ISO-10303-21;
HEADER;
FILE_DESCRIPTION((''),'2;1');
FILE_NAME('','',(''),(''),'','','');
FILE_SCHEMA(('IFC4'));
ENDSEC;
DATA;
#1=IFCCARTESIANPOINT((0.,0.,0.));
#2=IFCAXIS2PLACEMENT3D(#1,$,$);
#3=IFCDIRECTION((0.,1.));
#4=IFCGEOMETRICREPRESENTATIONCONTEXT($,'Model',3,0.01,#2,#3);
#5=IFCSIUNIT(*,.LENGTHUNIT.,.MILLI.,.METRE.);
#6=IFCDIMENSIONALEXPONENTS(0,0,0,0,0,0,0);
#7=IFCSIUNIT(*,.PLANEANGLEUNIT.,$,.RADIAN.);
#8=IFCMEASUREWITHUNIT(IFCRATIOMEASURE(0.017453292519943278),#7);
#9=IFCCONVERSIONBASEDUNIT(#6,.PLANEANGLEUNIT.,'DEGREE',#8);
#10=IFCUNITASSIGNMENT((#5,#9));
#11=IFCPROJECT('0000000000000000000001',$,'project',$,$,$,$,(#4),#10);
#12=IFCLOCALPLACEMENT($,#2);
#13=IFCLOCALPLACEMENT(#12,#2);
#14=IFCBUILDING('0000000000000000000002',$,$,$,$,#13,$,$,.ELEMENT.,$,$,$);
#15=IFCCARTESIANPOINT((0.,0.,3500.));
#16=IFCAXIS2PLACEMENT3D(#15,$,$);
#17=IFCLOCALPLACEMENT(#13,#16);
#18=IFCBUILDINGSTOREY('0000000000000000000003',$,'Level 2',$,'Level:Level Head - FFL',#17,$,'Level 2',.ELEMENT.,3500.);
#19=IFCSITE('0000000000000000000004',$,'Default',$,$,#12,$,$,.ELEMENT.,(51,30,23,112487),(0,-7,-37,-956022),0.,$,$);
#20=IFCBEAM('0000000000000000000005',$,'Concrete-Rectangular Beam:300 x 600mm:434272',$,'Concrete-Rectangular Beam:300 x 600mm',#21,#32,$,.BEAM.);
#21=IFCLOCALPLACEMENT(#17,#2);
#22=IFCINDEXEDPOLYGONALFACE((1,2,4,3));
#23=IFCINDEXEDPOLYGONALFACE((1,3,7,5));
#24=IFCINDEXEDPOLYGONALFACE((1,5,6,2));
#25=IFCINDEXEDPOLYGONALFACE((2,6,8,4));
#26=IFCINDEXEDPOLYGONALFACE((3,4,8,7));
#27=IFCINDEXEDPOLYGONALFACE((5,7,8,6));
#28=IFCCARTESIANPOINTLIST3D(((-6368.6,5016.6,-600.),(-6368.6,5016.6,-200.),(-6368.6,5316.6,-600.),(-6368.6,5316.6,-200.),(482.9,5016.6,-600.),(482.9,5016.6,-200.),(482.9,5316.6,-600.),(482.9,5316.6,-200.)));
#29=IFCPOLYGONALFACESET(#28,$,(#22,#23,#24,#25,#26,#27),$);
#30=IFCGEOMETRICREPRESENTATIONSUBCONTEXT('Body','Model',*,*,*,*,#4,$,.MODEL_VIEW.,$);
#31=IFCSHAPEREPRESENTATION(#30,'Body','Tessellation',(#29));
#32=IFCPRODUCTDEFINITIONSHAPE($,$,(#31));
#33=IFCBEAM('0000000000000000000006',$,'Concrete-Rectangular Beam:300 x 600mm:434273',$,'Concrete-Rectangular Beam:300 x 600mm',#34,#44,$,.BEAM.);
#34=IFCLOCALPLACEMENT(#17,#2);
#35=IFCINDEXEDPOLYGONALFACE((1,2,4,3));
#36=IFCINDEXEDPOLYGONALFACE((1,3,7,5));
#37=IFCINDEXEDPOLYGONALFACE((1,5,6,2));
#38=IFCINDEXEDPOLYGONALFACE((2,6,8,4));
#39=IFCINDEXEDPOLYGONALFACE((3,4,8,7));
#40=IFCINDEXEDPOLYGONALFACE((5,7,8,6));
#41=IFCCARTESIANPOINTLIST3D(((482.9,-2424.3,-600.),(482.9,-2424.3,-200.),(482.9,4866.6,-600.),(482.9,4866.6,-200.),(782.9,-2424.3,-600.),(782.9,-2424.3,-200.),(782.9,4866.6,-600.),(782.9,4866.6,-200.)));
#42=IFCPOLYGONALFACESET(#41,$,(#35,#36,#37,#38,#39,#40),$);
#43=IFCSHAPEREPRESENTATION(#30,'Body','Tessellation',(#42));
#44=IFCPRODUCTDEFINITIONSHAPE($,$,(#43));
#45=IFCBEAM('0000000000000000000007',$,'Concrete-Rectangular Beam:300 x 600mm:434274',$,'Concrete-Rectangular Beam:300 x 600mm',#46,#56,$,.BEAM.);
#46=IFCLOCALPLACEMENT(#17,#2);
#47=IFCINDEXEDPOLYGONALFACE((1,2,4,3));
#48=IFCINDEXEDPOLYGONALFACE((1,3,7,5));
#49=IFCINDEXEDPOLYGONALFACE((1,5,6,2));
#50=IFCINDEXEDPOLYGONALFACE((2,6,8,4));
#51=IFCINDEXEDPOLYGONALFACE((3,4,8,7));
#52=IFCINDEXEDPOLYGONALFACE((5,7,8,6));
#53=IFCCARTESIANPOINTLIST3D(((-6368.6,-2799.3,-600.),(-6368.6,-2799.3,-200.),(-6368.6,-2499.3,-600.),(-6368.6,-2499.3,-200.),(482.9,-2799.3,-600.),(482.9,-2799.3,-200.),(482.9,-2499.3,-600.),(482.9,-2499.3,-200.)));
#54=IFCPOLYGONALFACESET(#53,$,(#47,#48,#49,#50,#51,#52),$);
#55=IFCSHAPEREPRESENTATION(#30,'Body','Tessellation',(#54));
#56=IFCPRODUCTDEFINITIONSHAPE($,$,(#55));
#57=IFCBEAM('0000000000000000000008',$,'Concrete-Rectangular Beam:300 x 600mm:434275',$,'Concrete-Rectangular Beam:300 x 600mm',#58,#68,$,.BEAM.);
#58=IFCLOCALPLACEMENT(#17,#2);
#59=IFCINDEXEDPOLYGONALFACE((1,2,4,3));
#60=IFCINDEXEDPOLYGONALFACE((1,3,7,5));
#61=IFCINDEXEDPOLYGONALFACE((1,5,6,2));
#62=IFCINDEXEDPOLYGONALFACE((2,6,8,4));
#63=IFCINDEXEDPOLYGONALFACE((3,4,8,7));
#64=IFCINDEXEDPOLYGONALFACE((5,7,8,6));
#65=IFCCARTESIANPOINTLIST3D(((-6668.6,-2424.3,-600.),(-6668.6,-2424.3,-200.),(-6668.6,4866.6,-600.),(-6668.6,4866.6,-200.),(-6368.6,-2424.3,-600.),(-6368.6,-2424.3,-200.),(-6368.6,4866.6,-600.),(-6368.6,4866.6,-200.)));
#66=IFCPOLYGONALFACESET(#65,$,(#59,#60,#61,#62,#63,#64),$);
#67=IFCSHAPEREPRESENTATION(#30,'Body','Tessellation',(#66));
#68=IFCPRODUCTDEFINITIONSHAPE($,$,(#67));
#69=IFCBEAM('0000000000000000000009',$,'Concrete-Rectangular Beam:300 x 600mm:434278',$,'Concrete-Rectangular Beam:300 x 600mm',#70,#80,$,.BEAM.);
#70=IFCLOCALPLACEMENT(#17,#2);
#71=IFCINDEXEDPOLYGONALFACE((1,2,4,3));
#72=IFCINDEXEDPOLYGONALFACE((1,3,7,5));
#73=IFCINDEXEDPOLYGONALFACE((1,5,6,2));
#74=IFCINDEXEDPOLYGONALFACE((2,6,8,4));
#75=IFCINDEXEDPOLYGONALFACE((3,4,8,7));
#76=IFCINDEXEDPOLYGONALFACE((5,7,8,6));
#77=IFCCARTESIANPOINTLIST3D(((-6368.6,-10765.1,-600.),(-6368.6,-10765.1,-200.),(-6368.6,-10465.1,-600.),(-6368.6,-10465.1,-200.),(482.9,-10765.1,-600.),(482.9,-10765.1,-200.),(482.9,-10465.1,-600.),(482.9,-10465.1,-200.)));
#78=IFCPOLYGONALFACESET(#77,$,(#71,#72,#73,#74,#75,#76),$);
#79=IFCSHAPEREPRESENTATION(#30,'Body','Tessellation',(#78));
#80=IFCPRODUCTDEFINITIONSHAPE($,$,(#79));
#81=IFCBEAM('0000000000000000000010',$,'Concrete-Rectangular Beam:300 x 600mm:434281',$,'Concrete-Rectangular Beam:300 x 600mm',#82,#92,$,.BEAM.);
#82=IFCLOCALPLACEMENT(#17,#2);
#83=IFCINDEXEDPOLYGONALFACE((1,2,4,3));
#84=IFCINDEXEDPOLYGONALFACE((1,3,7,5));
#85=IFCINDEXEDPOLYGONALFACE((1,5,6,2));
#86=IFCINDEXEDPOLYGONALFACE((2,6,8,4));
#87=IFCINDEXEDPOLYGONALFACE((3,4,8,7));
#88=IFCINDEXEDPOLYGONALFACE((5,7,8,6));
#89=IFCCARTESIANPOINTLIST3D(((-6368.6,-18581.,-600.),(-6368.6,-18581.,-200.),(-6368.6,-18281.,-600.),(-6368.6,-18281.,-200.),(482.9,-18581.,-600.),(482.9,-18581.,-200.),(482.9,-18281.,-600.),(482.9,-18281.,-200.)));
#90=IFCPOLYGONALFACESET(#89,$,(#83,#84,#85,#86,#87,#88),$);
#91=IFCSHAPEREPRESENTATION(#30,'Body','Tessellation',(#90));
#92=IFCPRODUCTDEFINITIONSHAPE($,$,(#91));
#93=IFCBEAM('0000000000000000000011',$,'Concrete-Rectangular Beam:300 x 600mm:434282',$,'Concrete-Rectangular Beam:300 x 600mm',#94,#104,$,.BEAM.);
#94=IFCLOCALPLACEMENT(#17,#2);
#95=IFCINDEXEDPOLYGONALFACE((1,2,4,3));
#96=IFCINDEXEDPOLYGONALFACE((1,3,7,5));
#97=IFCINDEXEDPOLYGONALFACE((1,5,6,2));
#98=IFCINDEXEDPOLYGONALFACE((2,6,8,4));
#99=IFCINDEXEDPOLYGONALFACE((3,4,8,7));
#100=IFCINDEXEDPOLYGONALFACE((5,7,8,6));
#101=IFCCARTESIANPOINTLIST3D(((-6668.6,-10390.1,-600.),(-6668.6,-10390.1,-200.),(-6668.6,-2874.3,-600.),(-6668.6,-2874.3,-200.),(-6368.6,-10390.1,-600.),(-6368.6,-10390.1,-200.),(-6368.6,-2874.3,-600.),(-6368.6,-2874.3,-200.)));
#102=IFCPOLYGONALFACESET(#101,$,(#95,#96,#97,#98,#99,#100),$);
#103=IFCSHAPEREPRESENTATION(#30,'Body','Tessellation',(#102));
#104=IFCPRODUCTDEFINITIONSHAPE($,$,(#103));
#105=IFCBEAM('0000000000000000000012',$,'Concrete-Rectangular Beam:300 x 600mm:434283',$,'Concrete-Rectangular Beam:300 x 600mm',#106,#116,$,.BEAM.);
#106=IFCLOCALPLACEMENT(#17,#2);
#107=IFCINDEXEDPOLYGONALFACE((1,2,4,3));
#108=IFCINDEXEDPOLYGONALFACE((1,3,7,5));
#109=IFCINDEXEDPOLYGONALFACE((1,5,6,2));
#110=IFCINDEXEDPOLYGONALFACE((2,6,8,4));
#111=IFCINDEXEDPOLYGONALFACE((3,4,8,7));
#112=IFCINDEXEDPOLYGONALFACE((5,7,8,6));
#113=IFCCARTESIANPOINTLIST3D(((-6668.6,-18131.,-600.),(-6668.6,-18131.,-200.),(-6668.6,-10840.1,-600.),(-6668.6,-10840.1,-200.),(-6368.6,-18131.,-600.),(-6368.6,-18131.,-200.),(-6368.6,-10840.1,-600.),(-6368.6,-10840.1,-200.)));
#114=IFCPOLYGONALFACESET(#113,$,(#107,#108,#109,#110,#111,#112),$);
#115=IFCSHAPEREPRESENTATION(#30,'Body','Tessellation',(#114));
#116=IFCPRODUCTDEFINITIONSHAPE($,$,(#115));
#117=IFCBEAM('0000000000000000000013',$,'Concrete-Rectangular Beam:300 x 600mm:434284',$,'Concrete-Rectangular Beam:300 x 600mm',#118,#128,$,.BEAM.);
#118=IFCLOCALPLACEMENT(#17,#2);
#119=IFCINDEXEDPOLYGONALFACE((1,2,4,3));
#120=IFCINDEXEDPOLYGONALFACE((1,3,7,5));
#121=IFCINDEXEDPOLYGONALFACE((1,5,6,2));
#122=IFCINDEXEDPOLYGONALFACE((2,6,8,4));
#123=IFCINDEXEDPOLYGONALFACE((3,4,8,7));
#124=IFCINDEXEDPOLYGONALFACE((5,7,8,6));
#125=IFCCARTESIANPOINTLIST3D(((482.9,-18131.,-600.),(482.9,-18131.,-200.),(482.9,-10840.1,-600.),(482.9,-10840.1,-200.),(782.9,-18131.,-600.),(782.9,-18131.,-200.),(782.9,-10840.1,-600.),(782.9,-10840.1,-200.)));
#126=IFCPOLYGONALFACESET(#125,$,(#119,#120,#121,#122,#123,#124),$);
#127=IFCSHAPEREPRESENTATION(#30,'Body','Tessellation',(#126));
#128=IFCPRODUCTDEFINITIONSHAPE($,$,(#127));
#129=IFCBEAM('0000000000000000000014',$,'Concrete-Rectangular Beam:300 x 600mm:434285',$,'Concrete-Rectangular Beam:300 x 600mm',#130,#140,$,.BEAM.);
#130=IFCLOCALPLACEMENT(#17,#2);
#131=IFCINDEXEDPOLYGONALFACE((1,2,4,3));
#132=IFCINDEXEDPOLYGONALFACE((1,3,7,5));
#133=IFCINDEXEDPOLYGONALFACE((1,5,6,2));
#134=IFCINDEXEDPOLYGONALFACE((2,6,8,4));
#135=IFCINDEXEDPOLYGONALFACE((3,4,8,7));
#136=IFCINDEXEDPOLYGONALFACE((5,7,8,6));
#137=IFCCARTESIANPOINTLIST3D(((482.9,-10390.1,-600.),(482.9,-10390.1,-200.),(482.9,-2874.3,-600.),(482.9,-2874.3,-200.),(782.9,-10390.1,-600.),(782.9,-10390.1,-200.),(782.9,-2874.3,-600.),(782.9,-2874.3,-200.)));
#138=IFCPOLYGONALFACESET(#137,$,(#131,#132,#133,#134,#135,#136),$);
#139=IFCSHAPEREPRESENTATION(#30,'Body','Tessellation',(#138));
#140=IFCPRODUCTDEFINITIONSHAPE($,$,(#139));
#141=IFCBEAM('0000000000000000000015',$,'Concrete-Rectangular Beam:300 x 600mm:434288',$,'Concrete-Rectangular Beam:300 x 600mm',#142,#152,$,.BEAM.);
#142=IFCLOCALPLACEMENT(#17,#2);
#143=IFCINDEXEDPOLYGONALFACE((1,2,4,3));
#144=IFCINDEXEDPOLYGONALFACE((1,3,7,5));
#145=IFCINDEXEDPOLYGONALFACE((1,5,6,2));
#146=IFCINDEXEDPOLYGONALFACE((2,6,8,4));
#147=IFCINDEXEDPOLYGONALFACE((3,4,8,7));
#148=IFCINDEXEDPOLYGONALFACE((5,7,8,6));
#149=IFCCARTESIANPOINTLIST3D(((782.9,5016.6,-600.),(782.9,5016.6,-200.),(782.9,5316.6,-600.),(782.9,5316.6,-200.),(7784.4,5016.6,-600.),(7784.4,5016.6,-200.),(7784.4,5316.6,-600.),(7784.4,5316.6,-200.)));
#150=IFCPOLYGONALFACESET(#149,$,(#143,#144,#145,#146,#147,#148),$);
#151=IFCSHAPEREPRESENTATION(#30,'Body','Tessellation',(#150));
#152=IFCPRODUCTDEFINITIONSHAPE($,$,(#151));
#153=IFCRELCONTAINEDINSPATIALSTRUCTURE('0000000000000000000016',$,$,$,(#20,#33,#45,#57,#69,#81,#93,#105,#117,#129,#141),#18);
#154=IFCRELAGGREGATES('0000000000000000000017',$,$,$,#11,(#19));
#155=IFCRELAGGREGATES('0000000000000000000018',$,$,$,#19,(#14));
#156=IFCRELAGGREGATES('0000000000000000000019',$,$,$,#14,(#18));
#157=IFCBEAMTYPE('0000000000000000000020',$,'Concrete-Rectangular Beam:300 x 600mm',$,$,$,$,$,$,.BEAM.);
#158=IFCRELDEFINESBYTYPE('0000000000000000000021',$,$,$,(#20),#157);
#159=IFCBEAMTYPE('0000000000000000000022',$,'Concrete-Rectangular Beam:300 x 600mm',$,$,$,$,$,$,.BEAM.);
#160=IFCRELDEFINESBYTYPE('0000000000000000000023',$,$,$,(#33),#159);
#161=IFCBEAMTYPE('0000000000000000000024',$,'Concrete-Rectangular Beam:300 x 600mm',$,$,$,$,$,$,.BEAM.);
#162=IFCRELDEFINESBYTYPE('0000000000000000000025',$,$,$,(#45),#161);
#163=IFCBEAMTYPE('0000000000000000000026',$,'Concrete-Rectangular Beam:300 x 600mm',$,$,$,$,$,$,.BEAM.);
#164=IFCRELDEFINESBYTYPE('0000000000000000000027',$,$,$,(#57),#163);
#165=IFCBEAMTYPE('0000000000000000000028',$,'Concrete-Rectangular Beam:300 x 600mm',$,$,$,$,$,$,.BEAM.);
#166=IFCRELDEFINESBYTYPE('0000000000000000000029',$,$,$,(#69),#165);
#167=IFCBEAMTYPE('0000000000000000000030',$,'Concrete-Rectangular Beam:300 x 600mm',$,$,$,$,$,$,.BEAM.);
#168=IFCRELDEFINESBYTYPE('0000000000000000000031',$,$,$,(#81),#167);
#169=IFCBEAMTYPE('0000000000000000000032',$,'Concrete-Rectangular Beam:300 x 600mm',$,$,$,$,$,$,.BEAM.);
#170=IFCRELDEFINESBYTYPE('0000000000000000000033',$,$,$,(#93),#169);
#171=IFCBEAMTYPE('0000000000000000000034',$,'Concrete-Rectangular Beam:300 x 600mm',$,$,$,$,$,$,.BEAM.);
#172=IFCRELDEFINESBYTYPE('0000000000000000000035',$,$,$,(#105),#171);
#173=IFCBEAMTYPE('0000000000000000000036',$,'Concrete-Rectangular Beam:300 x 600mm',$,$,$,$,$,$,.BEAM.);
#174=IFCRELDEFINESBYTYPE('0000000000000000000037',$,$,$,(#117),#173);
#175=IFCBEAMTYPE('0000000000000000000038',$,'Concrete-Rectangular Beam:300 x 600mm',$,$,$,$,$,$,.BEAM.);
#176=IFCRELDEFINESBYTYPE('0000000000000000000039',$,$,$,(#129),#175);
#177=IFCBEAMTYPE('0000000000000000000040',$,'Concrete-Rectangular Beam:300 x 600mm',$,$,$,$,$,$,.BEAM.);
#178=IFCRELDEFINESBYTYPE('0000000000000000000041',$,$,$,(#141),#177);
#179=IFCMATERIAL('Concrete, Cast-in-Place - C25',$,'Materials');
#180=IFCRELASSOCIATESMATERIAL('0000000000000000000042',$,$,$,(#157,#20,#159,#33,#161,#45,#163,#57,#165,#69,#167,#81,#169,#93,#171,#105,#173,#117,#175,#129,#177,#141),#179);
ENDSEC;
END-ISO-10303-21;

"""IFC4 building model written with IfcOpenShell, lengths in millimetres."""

from ifc_helpers import new_model, entity, si_unit, converted_unit, direction, frame, origin, place, context, subcontext, project, spatial, indexed_curve, outline, extrude, source, transform, mapped, material, type_object, type_shapes, element, save


model = new_model("IFC4")

# Units and contexts
model_context = context("Model", 3, precision=0.01, world=origin(), true_north=direction((0.0, 1.0)))
body_context = subcontext(model_context, "Body", "Model", "MODEL_VIEW")
ifc_project = project(units=[si_unit("LENGTHUNIT", "METRE", prefix="MILLI"), converted_unit("PLANEANGLEUNIT", "DEGREE", entity("IfcRatioMeasure", 0.017453292519943278), si_unit("PLANEANGLEUNIT", "RADIAN"), dimensions=[0, 0, 0, 0, 0, 0, 0])], contexts=[model_context])

# Site, building, storey
site_placement = place(None, origin())
site = spatial("IfcSite", under=ifc_project, at=site_placement, Name="Default", CompositionType="ELEMENT", RefLatitude=(51, 30, 23, 112487), RefLongitude=(0, -7, -37, -956022), RefElevation=0.0)
building_placement = place(site_placement, origin())
building = spatial("IfcBuilding", under=site, at=building_placement, CompositionType="ELEMENT")
storey_placement = place(building_placement, frame((0.0, 0.0, 3500.0)))
storey = spatial("IfcBuildingStorey", under=building, at=storey_placement, Name="Level 2", ObjectType="Level:Level Head - FFL", LongName="Level 2", CompositionType="ELEMENT", Elevation=3500.0)

# Beams
ifc_material = material(Name="Concrete, Cast-in-Place - C25", Category="Materials")
beam_type_1 = type_object("IfcBeamType", Name="Concrete-Rectangular Beam:300 x 600mm", PredefinedType="BEAM", material=ifc_material)
shared_shape_1 = source(origin(), body_context, "Body", "SweptSolid", [
    extrude(outline(indexed_curve([(-200.0, -150.0), (200.0, -150.0), (200.0, 150.0), (-200.0, 150.0), (-200.0, -150.0)], self_intersect=False)), frame((-6368.6, 5166.6, 3100.0), z_axis=(1.0, 0.0, 0.0), x_axis=(0.0, 0.0, -1.0)), (0.0, 0.0, 1.0), 6851.5),
])
type_shapes(beam_type_1, [shared_shape_1])
beam_1_placement = place(storey_placement, frame((0.0, 0.0, -3500.0)))
element("IfcBeam", 1, at=beam_1_placement, inside=storey, type_object=beam_type_1, material=ifc_material, Name="Concrete-Rectangular Beam:300 x 600mm:434272", ObjectType="Concrete-Rectangular Beam:300 x 600mm", PredefinedType="BEAM", context=body_context, shape_type="MappedRepresentation", body=[
    mapped(shared_shape_1, transform((0.0, 0.0, 0.0), scale=1.0)),
])
beam_type_2 = type_object("IfcBeamType", Name="Concrete-Rectangular Beam:300 x 600mm", PredefinedType="BEAM", material=ifc_material)
shared_shape_2 = source(origin(), body_context, "Body", "SweptSolid", [
    extrude(outline(indexed_curve([(-150.0, -200.0), (150.0, -200.0), (150.0, 200.0), (-150.0, 200.0), (-150.0, -200.0)], self_intersect=False)), frame((632.9, 4866.6, 3100.0), z_axis=(0.0, -1.0, 0.0), x_axis=(-1.0, 0.0, 0.0)), (0.0, 0.0, 1.0), 7290.9),
])
type_shapes(beam_type_2, [shared_shape_2])
beam_2_placement = place(storey_placement, frame((0.0, 0.0, -3500.0)))
element("IfcBeam", 2, at=beam_2_placement, inside=storey, type_object=beam_type_2, material=ifc_material, Name="Concrete-Rectangular Beam:300 x 600mm:434273", ObjectType="Concrete-Rectangular Beam:300 x 600mm", PredefinedType="BEAM", context=body_context, shape_type="MappedRepresentation", body=[
    mapped(shared_shape_2, transform((0.0, 0.0, 0.0), scale=1.0)),
])
beam_type_3 = type_object("IfcBeamType", Name="Concrete-Rectangular Beam:300 x 600mm", PredefinedType="BEAM", material=ifc_material)
shared_shape_3 = source(origin(), body_context, "Body", "SweptSolid", [
    extrude(outline(indexed_curve([(-200.0, -150.0), (200.0, -150.0), (200.0, 150.0), (-200.0, 150.0), (-200.0, -150.0)], self_intersect=False)), frame((482.9, -2649.3, 3100.0), z_axis=(-1.0, 0.0, 0.0), x_axis=(0.0, 0.0, -1.0)), (0.0, 0.0, 1.0), 6851.5),
])
type_shapes(beam_type_3, [shared_shape_3])
beam_3_placement = place(storey_placement, frame((0.0, 0.0, -3500.0)))
element("IfcBeam", 3, at=beam_3_placement, inside=storey, type_object=beam_type_3, material=ifc_material, Name="Concrete-Rectangular Beam:300 x 600mm:434274", ObjectType="Concrete-Rectangular Beam:300 x 600mm", PredefinedType="BEAM", context=body_context, shape_type="MappedRepresentation", body=[
    mapped(shared_shape_3, transform((0.0, 0.0, 0.0), scale=1.0)),
])
beam_type_4 = type_object("IfcBeamType", Name="Concrete-Rectangular Beam:300 x 600mm", PredefinedType="BEAM", material=ifc_material)
shared_shape_4 = source(origin(), body_context, "Body", "SweptSolid", [
    extrude(outline(indexed_curve([(-150.0, -200.0), (150.0, -200.0), (150.0, 200.0), (-150.0, 200.0), (-150.0, -200.0)], self_intersect=False)), frame((-6518.6, -2424.3, 3100.0), z_axis=(0.0, 1.0, 0.0), x_axis=(-1.0, 0.0, 0.0)), (0.0, 0.0, 1.0), 7290.9),
])
type_shapes(beam_type_4, [shared_shape_4])
beam_4_placement = place(storey_placement, frame((0.0, 0.0, -3500.0)))
element("IfcBeam", 4, at=beam_4_placement, inside=storey, type_object=beam_type_4, material=ifc_material, Name="Concrete-Rectangular Beam:300 x 600mm:434275", ObjectType="Concrete-Rectangular Beam:300 x 600mm", PredefinedType="BEAM", context=body_context, shape_type="MappedRepresentation", body=[
    mapped(shared_shape_4, transform((0.0, 0.0, 0.0), scale=1.0)),
])
beam_type_5 = type_object("IfcBeamType", Name="Concrete-Rectangular Beam:300 x 600mm", PredefinedType="BEAM", material=ifc_material)
shared_shape_5 = source(origin(), body_context, "Body", "SweptSolid", [
    extrude(outline(indexed_curve([(-200.0, -150.0), (200.0, -150.0), (200.0, 150.0), (-200.0, 150.0), (-200.0, -150.0)], self_intersect=False)), frame((482.9, -10615.1, 3100.0), z_axis=(-1.0, 0.0, 0.0), x_axis=(0.0, 0.0, -1.0)), (0.0, 0.0, 1.0), 6851.5),
])
type_shapes(beam_type_5, [shared_shape_5])
beam_5_placement = place(storey_placement, frame((0.0, 0.0, -3500.0)))
element("IfcBeam", 5, at=beam_5_placement, inside=storey, type_object=beam_type_5, material=ifc_material, Name="Concrete-Rectangular Beam:300 x 600mm:434278", ObjectType="Concrete-Rectangular Beam:300 x 600mm", PredefinedType="BEAM", context=body_context, shape_type="MappedRepresentation", body=[
    mapped(shared_shape_5, transform((0.0, 0.0, 0.0), scale=1.0)),
])
beam_type_6 = type_object("IfcBeamType", Name="Concrete-Rectangular Beam:300 x 600mm", PredefinedType="BEAM", material=ifc_material)
shared_shape_6 = source(origin(), body_context, "Body", "SweptSolid", [
    extrude(outline(indexed_curve([(-200.0, -150.0), (200.0, -150.0), (200.0, 150.0), (-200.0, 150.0), (-200.0, -150.0)], self_intersect=False)), frame((482.9, -18431.0, 3100.0), z_axis=(-1.0, 0.0, 0.0), x_axis=(0.0, 0.0, -1.0)), (0.0, 0.0, 1.0), 6851.5),
])
type_shapes(beam_type_6, [shared_shape_6])
beam_6_placement = place(storey_placement, frame((0.0, 0.0, -3500.0)))
element("IfcBeam", 6, at=beam_6_placement, inside=storey, type_object=beam_type_6, material=ifc_material, Name="Concrete-Rectangular Beam:300 x 600mm:434281", ObjectType="Concrete-Rectangular Beam:300 x 600mm", PredefinedType="BEAM", context=body_context, shape_type="MappedRepresentation", body=[
    mapped(shared_shape_6, transform((0.0, 0.0, 0.0), scale=1.0)),
])
beam_type_7 = type_object("IfcBeamType", Name="Concrete-Rectangular Beam:300 x 600mm", PredefinedType="BEAM", material=ifc_material)
shared_shape_7 = source(origin(), body_context, "Body", "SweptSolid", [
    extrude(outline(indexed_curve([(-150.0, -200.0), (150.0, -200.0), (150.0, 200.0), (-150.0, 200.0), (-150.0, -200.0)], self_intersect=False)), frame((-6518.6, -2874.3, 3100.0), z_axis=(0.0, -1.0, 0.0), x_axis=(-1.0, 0.0, 0.0)), (0.0, 0.0, 1.0), 7515.9),
])
type_shapes(beam_type_7, [shared_shape_7])
beam_7_placement = place(storey_placement, frame((0.0, 0.0, -3500.0)))
element("IfcBeam", 7, at=beam_7_placement, inside=storey, type_object=beam_type_7, material=ifc_material, Name="Concrete-Rectangular Beam:300 x 600mm:434282", ObjectType="Concrete-Rectangular Beam:300 x 600mm", PredefinedType="BEAM", context=body_context, shape_type="MappedRepresentation", body=[
    mapped(shared_shape_7, transform((0.0, 0.0, 0.0), scale=1.0)),
])
beam_type_8 = type_object("IfcBeamType", Name="Concrete-Rectangular Beam:300 x 600mm", PredefinedType="BEAM", material=ifc_material)
shared_shape_8 = source(origin(), body_context, "Body", "SweptSolid", [
    extrude(outline(indexed_curve([(-150.0, -200.0), (150.0, -200.0), (150.0, 200.0), (-150.0, 200.0), (-150.0, -200.0)], self_intersect=False)), frame((-6518.6, -10840.1, 3100.0), z_axis=(0.0, -1.0, 0.0), x_axis=(-1.0, 0.0, 0.0)), (0.0, 0.0, 1.0), 7290.9),
])
type_shapes(beam_type_8, [shared_shape_8])
beam_8_placement = place(storey_placement, frame((0.0, 0.0, -3500.0)))
element("IfcBeam", 8, at=beam_8_placement, inside=storey, type_object=beam_type_8, material=ifc_material, Name="Concrete-Rectangular Beam:300 x 600mm:434283", ObjectType="Concrete-Rectangular Beam:300 x 600mm", PredefinedType="BEAM", context=body_context, shape_type="MappedRepresentation", body=[
    mapped(shared_shape_8, transform((0.0, 0.0, 0.0), scale=1.0)),
])
beam_type_9 = type_object("IfcBeamType", Name="Concrete-Rectangular Beam:300 x 600mm", PredefinedType="BEAM", material=ifc_material)
shared_shape_9 = source(origin(), body_context, "Body", "SweptSolid", [
    extrude(outline(indexed_curve([(-150.0, -200.0), (150.0, -200.0), (150.0, 200.0), (-150.0, 200.0), (-150.0, -200.0)], self_intersect=False)), frame((632.9, -18131.0, 3100.0), z_axis=(0.0, 1.0, 0.0), x_axis=(-1.0, 0.0, 0.0)), (0.0, 0.0, 1.0), 7290.9),
])
type_shapes(beam_type_9, [shared_shape_9])
beam_9_placement = place(storey_placement, frame((0.0, 0.0, -3500.0)))
element("IfcBeam", 9, at=beam_9_placement, inside=storey, type_object=beam_type_9, material=ifc_material, Name="Concrete-Rectangular Beam:300 x 600mm:434284", ObjectType="Concrete-Rectangular Beam:300 x 600mm", PredefinedType="BEAM", context=body_context, shape_type="MappedRepresentation", body=[
    mapped(shared_shape_9, transform((0.0, 0.0, 0.0), scale=1.0)),
])
beam_type_10 = type_object("IfcBeamType", Name="Concrete-Rectangular Beam:300 x 600mm", PredefinedType="BEAM", material=ifc_material)
shared_shape_10 = source(origin(), body_context, "Body", "SweptSolid", [
    extrude(outline(indexed_curve([(-150.0, -200.0), (150.0, -200.0), (150.0, 200.0), (-150.0, 200.0), (-150.0, -200.0)], self_intersect=False)), frame((632.9, -10390.1, 3100.0), z_axis=(0.0, 1.0, 0.0), x_axis=(-1.0, 0.0, 0.0)), (0.0, 0.0, 1.0), 7515.9),
])
type_shapes(beam_type_10, [shared_shape_10])
beam_10_placement = place(storey_placement, frame((0.0, 0.0, -3500.0)))
element("IfcBeam", 10, at=beam_10_placement, inside=storey, type_object=beam_type_10, material=ifc_material, Name="Concrete-Rectangular Beam:300 x 600mm:434285", ObjectType="Concrete-Rectangular Beam:300 x 600mm", PredefinedType="BEAM", context=body_context, shape_type="MappedRepresentation", body=[
    mapped(shared_shape_10, transform((0.0, 0.0, 0.0), scale=1.0)),
])
beam_type_11 = type_object("IfcBeamType", Name="Concrete-Rectangular Beam:300 x 600mm", PredefinedType="BEAM", material=ifc_material)
shared_shape_11 = source(origin(), body_context, "Body", "SweptSolid", [
    extrude(outline(indexed_curve([(-200.0, -150.0), (200.0, -150.0), (200.0, 150.0), (-200.0, 150.0), (-200.0, -150.0)], self_intersect=False)), frame((782.9, 5166.6, 3100.0), z_axis=(1.0, 0.0, 0.0), x_axis=(0.0, 0.0, -1.0)), (0.0, 0.0, 1.0), 7001.5),
])
type_shapes(beam_type_11, [shared_shape_11])
beam_11_placement = place(storey_placement, frame((0.0, 0.0, -3500.0)))
element("IfcBeam", 11, at=beam_11_placement, inside=storey, type_object=beam_type_11, material=ifc_material, Name="Concrete-Rectangular Beam:300 x 600mm:434288", ObjectType="Concrete-Rectangular Beam:300 x 600mm", PredefinedType="BEAM", context=body_context, shape_type="MappedRepresentation", body=[
    mapped(shared_shape_11, transform((0.0, 0.0, 0.0), scale=1.0)),
])

save(model, "model.ifc")
